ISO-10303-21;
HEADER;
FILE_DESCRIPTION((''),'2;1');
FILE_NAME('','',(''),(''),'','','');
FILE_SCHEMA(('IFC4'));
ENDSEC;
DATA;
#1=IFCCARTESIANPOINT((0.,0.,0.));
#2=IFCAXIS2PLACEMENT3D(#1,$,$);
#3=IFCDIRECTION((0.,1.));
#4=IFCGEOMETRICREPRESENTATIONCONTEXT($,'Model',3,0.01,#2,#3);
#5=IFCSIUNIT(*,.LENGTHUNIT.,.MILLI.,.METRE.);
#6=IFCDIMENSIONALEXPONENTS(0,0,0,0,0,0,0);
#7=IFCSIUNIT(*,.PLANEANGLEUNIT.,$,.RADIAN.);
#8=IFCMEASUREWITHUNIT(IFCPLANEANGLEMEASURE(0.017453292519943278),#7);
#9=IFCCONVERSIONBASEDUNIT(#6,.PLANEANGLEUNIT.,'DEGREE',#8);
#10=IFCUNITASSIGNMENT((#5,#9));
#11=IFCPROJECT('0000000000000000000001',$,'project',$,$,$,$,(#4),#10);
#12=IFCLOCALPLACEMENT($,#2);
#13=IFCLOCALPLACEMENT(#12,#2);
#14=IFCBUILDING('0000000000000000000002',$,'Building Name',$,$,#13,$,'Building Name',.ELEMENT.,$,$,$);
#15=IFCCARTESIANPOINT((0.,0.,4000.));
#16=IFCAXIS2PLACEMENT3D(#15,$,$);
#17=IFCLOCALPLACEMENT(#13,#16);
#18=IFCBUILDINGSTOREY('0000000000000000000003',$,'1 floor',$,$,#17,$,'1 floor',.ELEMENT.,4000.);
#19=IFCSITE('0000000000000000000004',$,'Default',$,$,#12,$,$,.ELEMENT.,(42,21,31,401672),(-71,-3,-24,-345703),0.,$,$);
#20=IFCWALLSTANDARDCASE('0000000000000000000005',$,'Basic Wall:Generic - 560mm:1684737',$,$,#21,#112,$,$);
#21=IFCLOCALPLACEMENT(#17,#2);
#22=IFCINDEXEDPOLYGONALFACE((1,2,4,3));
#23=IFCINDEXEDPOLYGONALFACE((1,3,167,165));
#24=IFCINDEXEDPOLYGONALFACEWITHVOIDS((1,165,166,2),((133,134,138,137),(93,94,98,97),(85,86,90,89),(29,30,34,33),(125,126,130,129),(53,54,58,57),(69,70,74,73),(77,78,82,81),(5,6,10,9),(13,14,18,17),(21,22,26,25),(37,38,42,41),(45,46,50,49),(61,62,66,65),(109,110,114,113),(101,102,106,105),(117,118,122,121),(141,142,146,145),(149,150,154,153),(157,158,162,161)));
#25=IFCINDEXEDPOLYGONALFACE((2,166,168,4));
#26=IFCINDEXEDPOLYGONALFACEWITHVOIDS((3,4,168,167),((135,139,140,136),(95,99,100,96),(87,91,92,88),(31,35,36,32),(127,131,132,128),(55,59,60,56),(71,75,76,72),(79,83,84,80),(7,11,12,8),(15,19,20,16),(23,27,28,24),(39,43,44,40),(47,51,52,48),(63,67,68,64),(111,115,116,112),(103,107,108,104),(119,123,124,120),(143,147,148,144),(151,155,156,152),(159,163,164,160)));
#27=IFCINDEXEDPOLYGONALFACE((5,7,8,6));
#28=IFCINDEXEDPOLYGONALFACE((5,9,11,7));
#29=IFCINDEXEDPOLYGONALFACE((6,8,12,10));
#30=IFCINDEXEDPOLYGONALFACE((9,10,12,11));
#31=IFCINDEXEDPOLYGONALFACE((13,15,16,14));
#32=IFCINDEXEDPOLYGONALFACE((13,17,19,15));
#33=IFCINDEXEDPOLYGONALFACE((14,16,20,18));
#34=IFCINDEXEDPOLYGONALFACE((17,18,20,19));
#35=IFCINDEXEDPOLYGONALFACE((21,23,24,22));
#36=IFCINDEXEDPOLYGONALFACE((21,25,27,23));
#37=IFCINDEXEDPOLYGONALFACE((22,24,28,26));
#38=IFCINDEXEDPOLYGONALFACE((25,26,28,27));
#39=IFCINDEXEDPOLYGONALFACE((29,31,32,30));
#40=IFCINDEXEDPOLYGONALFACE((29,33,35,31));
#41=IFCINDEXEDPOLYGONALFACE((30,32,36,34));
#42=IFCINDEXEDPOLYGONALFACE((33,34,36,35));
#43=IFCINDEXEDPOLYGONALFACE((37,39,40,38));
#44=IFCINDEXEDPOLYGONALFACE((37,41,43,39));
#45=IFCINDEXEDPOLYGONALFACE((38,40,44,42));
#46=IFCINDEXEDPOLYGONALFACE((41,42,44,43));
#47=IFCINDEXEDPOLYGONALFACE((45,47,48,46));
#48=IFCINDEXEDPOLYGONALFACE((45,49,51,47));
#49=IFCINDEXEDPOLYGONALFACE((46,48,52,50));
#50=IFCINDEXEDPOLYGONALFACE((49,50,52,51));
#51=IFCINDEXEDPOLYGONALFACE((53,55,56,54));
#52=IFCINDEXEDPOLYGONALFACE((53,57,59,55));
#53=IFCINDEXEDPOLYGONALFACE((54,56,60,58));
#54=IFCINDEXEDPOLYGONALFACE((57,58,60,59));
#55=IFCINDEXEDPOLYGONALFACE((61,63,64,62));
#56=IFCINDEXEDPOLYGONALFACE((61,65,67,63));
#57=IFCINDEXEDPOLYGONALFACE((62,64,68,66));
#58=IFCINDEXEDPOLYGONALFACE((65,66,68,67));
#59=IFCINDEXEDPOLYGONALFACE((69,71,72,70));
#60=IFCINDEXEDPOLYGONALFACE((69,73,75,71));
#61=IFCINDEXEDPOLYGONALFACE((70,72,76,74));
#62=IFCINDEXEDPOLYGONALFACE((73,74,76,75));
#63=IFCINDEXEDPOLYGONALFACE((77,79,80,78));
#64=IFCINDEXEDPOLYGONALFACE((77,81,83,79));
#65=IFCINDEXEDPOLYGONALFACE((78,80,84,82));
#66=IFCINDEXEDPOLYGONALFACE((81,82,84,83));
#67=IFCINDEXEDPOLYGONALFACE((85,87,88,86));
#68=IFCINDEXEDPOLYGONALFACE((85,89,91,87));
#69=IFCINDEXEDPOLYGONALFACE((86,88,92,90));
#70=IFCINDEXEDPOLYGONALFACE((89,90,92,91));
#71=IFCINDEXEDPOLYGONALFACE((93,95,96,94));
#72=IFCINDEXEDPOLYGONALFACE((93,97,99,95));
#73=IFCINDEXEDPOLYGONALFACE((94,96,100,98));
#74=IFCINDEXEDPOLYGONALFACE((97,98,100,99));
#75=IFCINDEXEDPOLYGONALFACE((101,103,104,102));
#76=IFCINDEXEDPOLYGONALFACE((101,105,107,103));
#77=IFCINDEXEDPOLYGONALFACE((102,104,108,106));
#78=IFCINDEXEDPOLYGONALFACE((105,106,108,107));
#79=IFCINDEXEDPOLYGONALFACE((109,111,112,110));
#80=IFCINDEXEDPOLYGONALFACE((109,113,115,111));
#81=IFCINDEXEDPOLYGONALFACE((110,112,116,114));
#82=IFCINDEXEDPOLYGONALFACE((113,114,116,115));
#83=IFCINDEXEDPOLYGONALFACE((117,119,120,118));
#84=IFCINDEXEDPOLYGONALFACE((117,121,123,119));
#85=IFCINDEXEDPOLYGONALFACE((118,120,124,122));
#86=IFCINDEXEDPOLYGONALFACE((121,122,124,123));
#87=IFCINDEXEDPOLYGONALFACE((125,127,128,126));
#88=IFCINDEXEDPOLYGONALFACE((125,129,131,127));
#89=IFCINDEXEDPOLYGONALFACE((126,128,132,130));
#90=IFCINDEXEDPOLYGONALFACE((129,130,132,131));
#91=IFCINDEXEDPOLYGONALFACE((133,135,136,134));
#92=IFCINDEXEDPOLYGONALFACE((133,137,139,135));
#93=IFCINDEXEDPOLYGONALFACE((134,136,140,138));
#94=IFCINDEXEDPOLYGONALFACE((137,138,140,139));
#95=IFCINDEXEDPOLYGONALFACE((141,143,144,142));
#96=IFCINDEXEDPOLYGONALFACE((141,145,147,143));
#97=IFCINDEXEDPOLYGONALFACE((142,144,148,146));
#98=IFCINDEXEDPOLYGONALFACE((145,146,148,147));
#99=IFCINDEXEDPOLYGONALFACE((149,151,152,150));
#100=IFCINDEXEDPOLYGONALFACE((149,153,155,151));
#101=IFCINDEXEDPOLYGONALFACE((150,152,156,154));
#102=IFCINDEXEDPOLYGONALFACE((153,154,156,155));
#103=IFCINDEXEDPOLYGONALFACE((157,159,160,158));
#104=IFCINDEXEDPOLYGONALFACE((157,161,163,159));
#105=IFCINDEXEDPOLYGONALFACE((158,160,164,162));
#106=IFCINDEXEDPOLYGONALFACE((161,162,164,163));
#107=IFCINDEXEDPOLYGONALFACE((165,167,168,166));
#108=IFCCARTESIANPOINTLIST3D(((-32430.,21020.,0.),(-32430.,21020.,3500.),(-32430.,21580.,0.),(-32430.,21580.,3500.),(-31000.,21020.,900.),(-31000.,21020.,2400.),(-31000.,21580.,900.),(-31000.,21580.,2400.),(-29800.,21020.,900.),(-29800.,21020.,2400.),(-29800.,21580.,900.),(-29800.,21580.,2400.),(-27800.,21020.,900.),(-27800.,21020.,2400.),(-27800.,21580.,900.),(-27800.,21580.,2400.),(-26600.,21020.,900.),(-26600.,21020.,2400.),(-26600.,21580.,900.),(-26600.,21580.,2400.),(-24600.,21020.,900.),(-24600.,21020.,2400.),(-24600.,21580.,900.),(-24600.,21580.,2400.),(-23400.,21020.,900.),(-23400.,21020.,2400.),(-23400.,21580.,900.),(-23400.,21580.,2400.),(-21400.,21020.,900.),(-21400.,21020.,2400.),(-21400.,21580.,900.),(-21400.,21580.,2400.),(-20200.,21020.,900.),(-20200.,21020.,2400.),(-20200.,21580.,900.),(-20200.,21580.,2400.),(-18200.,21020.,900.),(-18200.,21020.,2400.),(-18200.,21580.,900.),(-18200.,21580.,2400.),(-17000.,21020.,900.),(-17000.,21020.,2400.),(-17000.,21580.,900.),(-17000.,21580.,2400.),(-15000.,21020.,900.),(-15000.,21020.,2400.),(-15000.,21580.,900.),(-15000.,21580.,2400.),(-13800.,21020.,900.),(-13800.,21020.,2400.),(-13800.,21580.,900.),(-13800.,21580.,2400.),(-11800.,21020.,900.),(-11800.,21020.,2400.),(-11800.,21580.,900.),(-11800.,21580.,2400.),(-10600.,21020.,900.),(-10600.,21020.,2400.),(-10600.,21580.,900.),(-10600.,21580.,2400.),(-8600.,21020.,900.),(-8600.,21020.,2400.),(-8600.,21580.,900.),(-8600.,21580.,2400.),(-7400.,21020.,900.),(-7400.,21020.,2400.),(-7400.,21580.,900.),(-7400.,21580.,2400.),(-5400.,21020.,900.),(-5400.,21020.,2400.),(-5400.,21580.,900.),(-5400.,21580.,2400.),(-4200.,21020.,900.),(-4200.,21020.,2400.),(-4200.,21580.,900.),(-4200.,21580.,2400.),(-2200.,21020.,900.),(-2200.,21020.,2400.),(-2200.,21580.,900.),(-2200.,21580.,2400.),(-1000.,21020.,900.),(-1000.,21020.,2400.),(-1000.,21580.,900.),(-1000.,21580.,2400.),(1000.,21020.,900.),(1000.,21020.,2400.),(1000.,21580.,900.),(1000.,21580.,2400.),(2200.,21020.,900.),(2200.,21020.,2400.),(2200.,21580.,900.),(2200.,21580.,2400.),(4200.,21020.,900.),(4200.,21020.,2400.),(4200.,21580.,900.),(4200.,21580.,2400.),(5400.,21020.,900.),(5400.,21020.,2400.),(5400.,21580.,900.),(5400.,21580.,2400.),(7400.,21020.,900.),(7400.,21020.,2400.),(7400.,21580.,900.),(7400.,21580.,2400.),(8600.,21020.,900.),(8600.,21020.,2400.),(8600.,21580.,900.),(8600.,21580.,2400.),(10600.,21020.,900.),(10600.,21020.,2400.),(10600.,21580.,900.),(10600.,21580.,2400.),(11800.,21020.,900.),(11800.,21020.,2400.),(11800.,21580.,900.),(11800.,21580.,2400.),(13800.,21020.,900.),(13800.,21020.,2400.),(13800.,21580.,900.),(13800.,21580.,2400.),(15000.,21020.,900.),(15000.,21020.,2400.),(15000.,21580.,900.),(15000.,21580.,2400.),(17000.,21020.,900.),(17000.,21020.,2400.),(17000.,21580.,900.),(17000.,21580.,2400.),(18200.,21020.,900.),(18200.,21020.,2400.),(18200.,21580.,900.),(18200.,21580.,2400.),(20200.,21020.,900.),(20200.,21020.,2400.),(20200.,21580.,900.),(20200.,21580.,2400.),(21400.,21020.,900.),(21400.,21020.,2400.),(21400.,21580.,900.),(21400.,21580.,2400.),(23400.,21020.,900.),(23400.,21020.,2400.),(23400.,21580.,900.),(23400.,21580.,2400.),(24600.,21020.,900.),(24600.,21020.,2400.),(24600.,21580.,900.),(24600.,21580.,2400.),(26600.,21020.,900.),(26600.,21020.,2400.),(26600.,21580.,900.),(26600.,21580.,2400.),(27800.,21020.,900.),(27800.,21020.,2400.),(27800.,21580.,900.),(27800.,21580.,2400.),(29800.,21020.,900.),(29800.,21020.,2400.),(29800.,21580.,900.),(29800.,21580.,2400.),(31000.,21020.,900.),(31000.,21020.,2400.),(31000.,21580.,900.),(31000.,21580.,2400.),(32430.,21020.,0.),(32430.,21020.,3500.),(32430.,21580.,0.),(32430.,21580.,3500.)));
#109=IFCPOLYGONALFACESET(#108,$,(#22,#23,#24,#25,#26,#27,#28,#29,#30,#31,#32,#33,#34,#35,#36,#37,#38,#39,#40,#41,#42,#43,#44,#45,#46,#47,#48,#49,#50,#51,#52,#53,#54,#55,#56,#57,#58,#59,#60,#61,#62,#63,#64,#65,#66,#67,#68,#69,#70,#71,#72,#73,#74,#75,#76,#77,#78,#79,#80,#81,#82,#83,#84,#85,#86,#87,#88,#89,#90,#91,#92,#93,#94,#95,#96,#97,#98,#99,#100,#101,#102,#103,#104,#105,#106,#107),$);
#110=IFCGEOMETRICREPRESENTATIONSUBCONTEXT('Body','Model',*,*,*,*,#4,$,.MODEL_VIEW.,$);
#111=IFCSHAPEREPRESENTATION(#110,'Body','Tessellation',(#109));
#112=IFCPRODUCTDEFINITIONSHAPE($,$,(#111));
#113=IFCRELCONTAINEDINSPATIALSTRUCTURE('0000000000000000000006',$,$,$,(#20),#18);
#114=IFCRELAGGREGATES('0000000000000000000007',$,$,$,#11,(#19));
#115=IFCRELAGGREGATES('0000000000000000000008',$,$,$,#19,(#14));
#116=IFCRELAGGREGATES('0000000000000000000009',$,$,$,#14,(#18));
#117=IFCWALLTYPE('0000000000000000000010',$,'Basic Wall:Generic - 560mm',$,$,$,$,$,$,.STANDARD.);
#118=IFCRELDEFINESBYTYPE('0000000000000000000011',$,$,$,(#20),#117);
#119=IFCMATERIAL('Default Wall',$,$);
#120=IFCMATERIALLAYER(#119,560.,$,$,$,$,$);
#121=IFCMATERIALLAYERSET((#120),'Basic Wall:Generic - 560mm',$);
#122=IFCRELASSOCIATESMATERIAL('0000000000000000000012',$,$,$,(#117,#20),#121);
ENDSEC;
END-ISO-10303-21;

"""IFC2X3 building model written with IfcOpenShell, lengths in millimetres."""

from ifc_helpers import new_model, entity, si_unit, converted_unit, direction, frame, frame_2d, origin, place, context, subcontext, project, spatial, rectangle, extrude, material, layer, layer_set, layer_usage, type_object, element, save


model = new_model("IFC2X3")

# Units and contexts
model_context = context("Model", 3, precision=0.01, world=origin(), true_north=direction((0.0, 1.0)))
body_context = subcontext(model_context, "Body", "Model", "MODEL_VIEW")
ifc_project = project(units=[si_unit("LENGTHUNIT", "METRE", prefix="MILLI"), converted_unit("PLANEANGLEUNIT", "DEGREE", entity("IfcPlaneAngleMeasure", 0.017453292519943278), si_unit("PLANEANGLEUNIT", "RADIAN"), dimensions=[0, 0, 0, 0, 0, 0, 0])], contexts=[model_context])

# Site, building, storey
site_placement = place(None, origin())
site = spatial("IfcSite", under=ifc_project, at=site_placement, Name="Default", CompositionType="ELEMENT", RefLatitude=(42, 21, 31, 401672), RefLongitude=(-71, -3, -24, -345703), RefElevation=0.0)
building_placement = place(site_placement, origin())
building = spatial("IfcBuilding", under=site, at=building_placement, Name="Building Name", LongName="Building Name", CompositionType="ELEMENT")
storey_placement = place(building_placement, frame((0.0, 0.0, 4000.0)))
storey = spatial("IfcBuildingStorey", under=building, at=storey_placement, Name="1 floor", LongName="1 floor", CompositionType="ELEMENT", Elevation=4000.0)

# Wall, openings
ifc_material_1 = material(Name="Default Wall")
ifc_layer = layer(ifc_material_1, 560.0)
ifc_layer_set = layer_set([ifc_layer], Name="Basic Wall:Generic - 560mm")
ifc_layer_usage = layer_usage(ifc_layer_set, "AXIS2", "NEGATIVE", 280.0)
wall_type = type_object("IfcWallType", Name="Basic Wall:Generic - 560mm", PredefinedType="STANDARD", material=ifc_layer_set)
wall_placement = place(storey_placement, frame((-32430.0, 21300.0, 0.0)))
wall = element("IfcWallStandardCase", 1, at=wall_placement, inside=storey, type_object=wall_type, material=ifc_layer_usage, Name="Basic Wall:Generic - 560mm:1684737", context=body_context, shape_type="SweptSolid", body=[
    extrude(rectangle(XDim=64860.0, YDim=560.0, at=frame_2d((32430.0, 0.0), x_axis=(-1.0, 0.0))), origin(), (0.0, 0.0, 1.0), 3500.0),
])
opening_1_placement = place(wall_placement, frame((52630.0, -280.0, 900.0)))
element("IfcOpeningElement", 2, at=opening_1_placement, cuts=wall, ObjectType="Opening", context=body_context, shape_type="SweptSolid", body=[
    extrude(rectangle(XDim=1500.0, YDim=1200.0, at=frame_2d((750.0, 600.0), x_axis=(-1.0, 0.0))), frame((0.0, 0.0, 0.0), z_axis=(0.0, 1.0, 0.0), x_axis=(0.0, 0.0, 1.0)), (0.0, 0.0, 1.0), 560.0),
])
opening_2_placement = place(wall_placement, frame((49430.0, -280.0, 900.0)))
element("IfcOpeningElement", 3, at=opening_2_placement, cuts=wall, ObjectType="Opening", context=body_context, shape_type="SweptSolid", body=[
    extrude(rectangle(XDim=1500.0, YDim=1200.0, at=frame_2d((750.0, 600.0), x_axis=(-1.0, 0.0))), frame((0.0, 0.0, 0.0), z_axis=(0.0, 1.0, 0.0), x_axis=(0.0, 0.0, 1.0)), (0.0, 0.0, 1.0), 560.0),
])
opening_3_placement = place(wall_placement, frame((46230.0, -280.0, 900.0)))
element("IfcOpeningElement", 4, at=opening_3_placement, cuts=wall, ObjectType="Opening", context=body_context, shape_type="SweptSolid", body=[
    extrude(rectangle(XDim=1500.0, YDim=1200.0, at=frame_2d((750.0, 600.0), x_axis=(-1.0, 0.0))), frame((0.0, 0.0, 0.0), z_axis=(0.0, 1.0, 0.0), x_axis=(0.0, 0.0, 1.0)), (0.0, 0.0, 1.0), 560.0),
])
opening_4_placement = place(wall_placement, frame((43030.0, -280.0, 900.0)))
element("IfcOpeningElement", 5, at=opening_4_placement, cuts=wall, ObjectType="Opening", context=body_context, shape_type="SweptSolid", body=[
    extrude(rectangle(XDim=1500.0, YDim=1200.0, at=frame_2d((750.0, 600.0), x_axis=(-1.0, 0.0))), frame((0.0, 0.0, 0.0), z_axis=(0.0, 1.0, 0.0), x_axis=(0.0, 0.0, 1.0)), (0.0, 0.0, 1.0), 560.0),
])
opening_5_placement = place(wall_placement, frame((39830.0, -280.0, 900.0)))
element("IfcOpeningElement", 6, at=opening_5_placement, cuts=wall, ObjectType="Opening", context=body_context, shape_type="SweptSolid", body=[
    extrude(rectangle(XDim=1500.0, YDim=1200.0, at=frame_2d((750.0, 600.0), x_axis=(-1.0, 0.0))), frame((0.0, 0.0, 0.0), z_axis=(0.0, 1.0, 0.0), x_axis=(0.0, 0.0, 1.0)), (0.0, 0.0, 1.0), 560.0),
])
opening_6_placement = place(wall_placement, frame((36630.0, -280.0, 900.0)))
element("IfcOpeningElement", 7, at=opening_6_placement, cuts=wall, ObjectType="Opening", context=body_context, shape_type="SweptSolid", body=[
    extrude(rectangle(XDim=1500.0, YDim=1200.0, at=frame_2d((750.0, 600.0), x_axis=(-1.0, 0.0))), frame((0.0, 0.0, 0.0), z_axis=(0.0, 1.0, 0.0), x_axis=(0.0, 0.0, 1.0)), (0.0, 0.0, 1.0), 560.0),
])
opening_7_placement = place(wall_placement, frame((33430.0, -280.0, 900.0)))
element("IfcOpeningElement", 8, at=opening_7_placement, cuts=wall, ObjectType="Opening", context=body_context, shape_type="SweptSolid", body=[
    extrude(rectangle(XDim=1500.0, YDim=1200.0, at=frame_2d((750.0, 600.0), x_axis=(-1.0, 0.0))), frame((0.0, 0.0, 0.0), z_axis=(0.0, 1.0, 0.0), x_axis=(0.0, 0.0, 1.0)), (0.0, 0.0, 1.0), 560.0),
])
opening_8_placement = place(wall_placement, frame((30230.0, -280.0, 900.0)))
element("IfcOpeningElement", 9, at=opening_8_placement, cuts=wall, ObjectType="Opening", context=body_context, shape_type="SweptSolid", body=[
    extrude(rectangle(XDim=1500.0, YDim=1200.0, at=frame_2d((750.0, 600.0), x_axis=(-1.0, 0.0))), frame((0.0, 0.0, 0.0), z_axis=(0.0, 1.0, 0.0), x_axis=(0.0, 0.0, 1.0)), (0.0, 0.0, 1.0), 560.0),
])
opening_9_placement = place(wall_placement, frame((27030.0, -280.0, 900.0)))
element("IfcOpeningElement", 10, at=opening_9_placement, cuts=wall, ObjectType="Opening", context=body_context, shape_type="SweptSolid", body=[
    extrude(rectangle(XDim=1500.0, YDim=1200.0, at=frame_2d((750.0, 600.0), x_axis=(-1.0, 0.0))), frame((0.0, 0.0, 0.0), z_axis=(0.0, 1.0, 0.0), x_axis=(0.0, 0.0, 1.0)), (0.0, 0.0, 1.0), 560.0),
])
opening_10_placement = place(wall_placement, frame((23830.0, -280.0, 900.0)))
element("IfcOpeningElement", 11, at=opening_10_placement, cuts=wall, ObjectType="Opening", context=body_context, shape_type="SweptSolid", body=[
    extrude(rectangle(XDim=1500.0, YDim=1200.0, at=frame_2d((750.0, 600.0), x_axis=(-1.0, 0.0))), frame((0.0, 0.0, 0.0), z_axis=(0.0, 1.0, 0.0), x_axis=(0.0, 0.0, 1.0)), (0.0, 0.0, 1.0), 560.0),
])
opening_11_placement = place(wall_placement, frame((20630.0, -280.0, 900.0)))
element("IfcOpeningElement", 12, at=opening_11_placement, cuts=wall, ObjectType="Opening", context=body_context, shape_type="SweptSolid", body=[
    extrude(rectangle(XDim=1500.0, YDim=1200.0, at=frame_2d((750.0, 600.0), x_axis=(-1.0, 0.0))), frame((0.0, 0.0, 0.0), z_axis=(0.0, 1.0, 0.0), x_axis=(0.0, 0.0, 1.0)), (0.0, 0.0, 1.0), 560.0),
])
opening_12_placement = place(wall_placement, frame((17430.0, -280.0, 900.0)))
element("IfcOpeningElement", 13, at=opening_12_placement, cuts=wall, ObjectType="Opening", context=body_context, shape_type="SweptSolid", body=[
    extrude(rectangle(XDim=1500.0, YDim=1200.0, at=frame_2d((750.0, 600.0), x_axis=(-1.0, 0.0))), frame((0.0, 0.0, 0.0), z_axis=(0.0, 1.0, 0.0), x_axis=(0.0, 0.0, 1.0)), (0.0, 0.0, 1.0), 560.0),
])
opening_13_placement = place(wall_placement, frame((14230.0, -280.0, 900.0)))
element("IfcOpeningElement", 14, at=opening_13_placement, cuts=wall, ObjectType="Opening", context=body_context, shape_type="SweptSolid", body=[
    extrude(rectangle(XDim=1500.0, YDim=1200.0, at=frame_2d((750.0, 600.0), x_axis=(-1.0, 0.0))), frame((0.0, 0.0, 0.0), z_axis=(0.0, 1.0, 0.0), x_axis=(0.0, 0.0, 1.0)), (0.0, 0.0, 1.0), 560.0),
])
opening_14_placement = place(wall_placement, frame((11030.0, -280.0, 900.0)))
element("IfcOpeningElement", 15, at=opening_14_placement, cuts=wall, ObjectType="Opening", context=body_context, shape_type="SweptSolid", body=[
    extrude(rectangle(XDim=1500.0, YDim=1200.0, at=frame_2d((750.0, 600.0), x_axis=(-1.0, 0.0))), frame((0.0, 0.0, 0.0), z_axis=(0.0, 1.0, 0.0), x_axis=(0.0, 0.0, 1.0)), (0.0, 0.0, 1.0), 560.0),
])
opening_15_placement = place(wall_placement, frame((7830.0, -280.0, 900.0)))
element("IfcOpeningElement", 16, at=opening_15_placement, cuts=wall, ObjectType="Opening", context=body_context, shape_type="SweptSolid", body=[
    extrude(rectangle(XDim=1500.0, YDim=1200.0, at=frame_2d((750.0, 600.0), x_axis=(-1.0, 0.0))), frame((0.0, 0.0, 0.0), z_axis=(0.0, 1.0, 0.0), x_axis=(0.0, 0.0, 1.0)), (0.0, 0.0, 1.0), 560.0),
])
opening_16_placement = place(wall_placement, frame((4630.0, -280.0, 900.0)))
element("IfcOpeningElement", 17, at=opening_16_placement, cuts=wall, ObjectType="Opening", context=body_context, shape_type="SweptSolid", body=[
    extrude(rectangle(XDim=1500.0, YDim=1200.0, at=frame_2d((750.0, 600.0), x_axis=(-1.0, 0.0))), frame((0.0, 0.0, 0.0), z_axis=(0.0, 1.0, 0.0), x_axis=(0.0, 0.0, 1.0)), (0.0, 0.0, 1.0), 560.0),
])
opening_17_placement = place(wall_placement, frame((1430.0, -280.0, 900.0)))
element("IfcOpeningElement", 18, at=opening_17_placement, cuts=wall, ObjectType="Opening", context=body_context, shape_type="SweptSolid", body=[
    extrude(rectangle(XDim=1500.0, YDim=1200.0, at=frame_2d((750.0, 600.0), x_axis=(-1.0, 0.0))), frame((0.0, 0.0, 0.0), z_axis=(0.0, 1.0, 0.0), x_axis=(0.0, 0.0, 1.0)), (0.0, 0.0, 1.0), 560.0),
])
opening_18_placement = place(wall_placement, frame((55830.0, -280.0, 900.0)))
element("IfcOpeningElement", 19, at=opening_18_placement, cuts=wall, ObjectType="Opening", context=body_context, shape_type="SweptSolid", body=[
    extrude(rectangle(XDim=1500.0, YDim=1200.0, at=frame_2d((750.0, 600.0), x_axis=(-1.0, 0.0))), frame((0.0, 0.0, 0.0), z_axis=(0.0, 1.0, 0.0), x_axis=(0.0, 0.0, 1.0)), (0.0, 0.0, 1.0), 560.0),
])
opening_19_placement = place(wall_placement, frame((59030.0, -280.0, 900.0)))
element("IfcOpeningElement", 20, at=opening_19_placement, cuts=wall, ObjectType="Opening", context=body_context, shape_type="SweptSolid", body=[
    extrude(rectangle(XDim=1500.0, YDim=1200.0, at=frame_2d((750.0, 600.0), x_axis=(-1.0, 0.0))), frame((0.0, 0.0, 0.0), z_axis=(0.0, 1.0, 0.0), x_axis=(0.0, 0.0, 1.0)), (0.0, 0.0, 1.0), 560.0),
])
opening_20_placement = place(wall_placement, frame((62230.0, -280.0, 900.0)))
element("IfcOpeningElement", 21, at=opening_20_placement, cuts=wall, ObjectType="Opening", context=body_context, shape_type="SweptSolid", body=[
    extrude(rectangle(XDim=1500.0, YDim=1200.0, at=frame_2d((750.0, 600.0), x_axis=(-1.0, 0.0))), frame((0.0, 0.0, 0.0), z_axis=(0.0, 1.0, 0.0), x_axis=(0.0, 0.0, 1.0)), (0.0, 0.0, 1.0), 560.0),
])

save(model, "model.ifc")
